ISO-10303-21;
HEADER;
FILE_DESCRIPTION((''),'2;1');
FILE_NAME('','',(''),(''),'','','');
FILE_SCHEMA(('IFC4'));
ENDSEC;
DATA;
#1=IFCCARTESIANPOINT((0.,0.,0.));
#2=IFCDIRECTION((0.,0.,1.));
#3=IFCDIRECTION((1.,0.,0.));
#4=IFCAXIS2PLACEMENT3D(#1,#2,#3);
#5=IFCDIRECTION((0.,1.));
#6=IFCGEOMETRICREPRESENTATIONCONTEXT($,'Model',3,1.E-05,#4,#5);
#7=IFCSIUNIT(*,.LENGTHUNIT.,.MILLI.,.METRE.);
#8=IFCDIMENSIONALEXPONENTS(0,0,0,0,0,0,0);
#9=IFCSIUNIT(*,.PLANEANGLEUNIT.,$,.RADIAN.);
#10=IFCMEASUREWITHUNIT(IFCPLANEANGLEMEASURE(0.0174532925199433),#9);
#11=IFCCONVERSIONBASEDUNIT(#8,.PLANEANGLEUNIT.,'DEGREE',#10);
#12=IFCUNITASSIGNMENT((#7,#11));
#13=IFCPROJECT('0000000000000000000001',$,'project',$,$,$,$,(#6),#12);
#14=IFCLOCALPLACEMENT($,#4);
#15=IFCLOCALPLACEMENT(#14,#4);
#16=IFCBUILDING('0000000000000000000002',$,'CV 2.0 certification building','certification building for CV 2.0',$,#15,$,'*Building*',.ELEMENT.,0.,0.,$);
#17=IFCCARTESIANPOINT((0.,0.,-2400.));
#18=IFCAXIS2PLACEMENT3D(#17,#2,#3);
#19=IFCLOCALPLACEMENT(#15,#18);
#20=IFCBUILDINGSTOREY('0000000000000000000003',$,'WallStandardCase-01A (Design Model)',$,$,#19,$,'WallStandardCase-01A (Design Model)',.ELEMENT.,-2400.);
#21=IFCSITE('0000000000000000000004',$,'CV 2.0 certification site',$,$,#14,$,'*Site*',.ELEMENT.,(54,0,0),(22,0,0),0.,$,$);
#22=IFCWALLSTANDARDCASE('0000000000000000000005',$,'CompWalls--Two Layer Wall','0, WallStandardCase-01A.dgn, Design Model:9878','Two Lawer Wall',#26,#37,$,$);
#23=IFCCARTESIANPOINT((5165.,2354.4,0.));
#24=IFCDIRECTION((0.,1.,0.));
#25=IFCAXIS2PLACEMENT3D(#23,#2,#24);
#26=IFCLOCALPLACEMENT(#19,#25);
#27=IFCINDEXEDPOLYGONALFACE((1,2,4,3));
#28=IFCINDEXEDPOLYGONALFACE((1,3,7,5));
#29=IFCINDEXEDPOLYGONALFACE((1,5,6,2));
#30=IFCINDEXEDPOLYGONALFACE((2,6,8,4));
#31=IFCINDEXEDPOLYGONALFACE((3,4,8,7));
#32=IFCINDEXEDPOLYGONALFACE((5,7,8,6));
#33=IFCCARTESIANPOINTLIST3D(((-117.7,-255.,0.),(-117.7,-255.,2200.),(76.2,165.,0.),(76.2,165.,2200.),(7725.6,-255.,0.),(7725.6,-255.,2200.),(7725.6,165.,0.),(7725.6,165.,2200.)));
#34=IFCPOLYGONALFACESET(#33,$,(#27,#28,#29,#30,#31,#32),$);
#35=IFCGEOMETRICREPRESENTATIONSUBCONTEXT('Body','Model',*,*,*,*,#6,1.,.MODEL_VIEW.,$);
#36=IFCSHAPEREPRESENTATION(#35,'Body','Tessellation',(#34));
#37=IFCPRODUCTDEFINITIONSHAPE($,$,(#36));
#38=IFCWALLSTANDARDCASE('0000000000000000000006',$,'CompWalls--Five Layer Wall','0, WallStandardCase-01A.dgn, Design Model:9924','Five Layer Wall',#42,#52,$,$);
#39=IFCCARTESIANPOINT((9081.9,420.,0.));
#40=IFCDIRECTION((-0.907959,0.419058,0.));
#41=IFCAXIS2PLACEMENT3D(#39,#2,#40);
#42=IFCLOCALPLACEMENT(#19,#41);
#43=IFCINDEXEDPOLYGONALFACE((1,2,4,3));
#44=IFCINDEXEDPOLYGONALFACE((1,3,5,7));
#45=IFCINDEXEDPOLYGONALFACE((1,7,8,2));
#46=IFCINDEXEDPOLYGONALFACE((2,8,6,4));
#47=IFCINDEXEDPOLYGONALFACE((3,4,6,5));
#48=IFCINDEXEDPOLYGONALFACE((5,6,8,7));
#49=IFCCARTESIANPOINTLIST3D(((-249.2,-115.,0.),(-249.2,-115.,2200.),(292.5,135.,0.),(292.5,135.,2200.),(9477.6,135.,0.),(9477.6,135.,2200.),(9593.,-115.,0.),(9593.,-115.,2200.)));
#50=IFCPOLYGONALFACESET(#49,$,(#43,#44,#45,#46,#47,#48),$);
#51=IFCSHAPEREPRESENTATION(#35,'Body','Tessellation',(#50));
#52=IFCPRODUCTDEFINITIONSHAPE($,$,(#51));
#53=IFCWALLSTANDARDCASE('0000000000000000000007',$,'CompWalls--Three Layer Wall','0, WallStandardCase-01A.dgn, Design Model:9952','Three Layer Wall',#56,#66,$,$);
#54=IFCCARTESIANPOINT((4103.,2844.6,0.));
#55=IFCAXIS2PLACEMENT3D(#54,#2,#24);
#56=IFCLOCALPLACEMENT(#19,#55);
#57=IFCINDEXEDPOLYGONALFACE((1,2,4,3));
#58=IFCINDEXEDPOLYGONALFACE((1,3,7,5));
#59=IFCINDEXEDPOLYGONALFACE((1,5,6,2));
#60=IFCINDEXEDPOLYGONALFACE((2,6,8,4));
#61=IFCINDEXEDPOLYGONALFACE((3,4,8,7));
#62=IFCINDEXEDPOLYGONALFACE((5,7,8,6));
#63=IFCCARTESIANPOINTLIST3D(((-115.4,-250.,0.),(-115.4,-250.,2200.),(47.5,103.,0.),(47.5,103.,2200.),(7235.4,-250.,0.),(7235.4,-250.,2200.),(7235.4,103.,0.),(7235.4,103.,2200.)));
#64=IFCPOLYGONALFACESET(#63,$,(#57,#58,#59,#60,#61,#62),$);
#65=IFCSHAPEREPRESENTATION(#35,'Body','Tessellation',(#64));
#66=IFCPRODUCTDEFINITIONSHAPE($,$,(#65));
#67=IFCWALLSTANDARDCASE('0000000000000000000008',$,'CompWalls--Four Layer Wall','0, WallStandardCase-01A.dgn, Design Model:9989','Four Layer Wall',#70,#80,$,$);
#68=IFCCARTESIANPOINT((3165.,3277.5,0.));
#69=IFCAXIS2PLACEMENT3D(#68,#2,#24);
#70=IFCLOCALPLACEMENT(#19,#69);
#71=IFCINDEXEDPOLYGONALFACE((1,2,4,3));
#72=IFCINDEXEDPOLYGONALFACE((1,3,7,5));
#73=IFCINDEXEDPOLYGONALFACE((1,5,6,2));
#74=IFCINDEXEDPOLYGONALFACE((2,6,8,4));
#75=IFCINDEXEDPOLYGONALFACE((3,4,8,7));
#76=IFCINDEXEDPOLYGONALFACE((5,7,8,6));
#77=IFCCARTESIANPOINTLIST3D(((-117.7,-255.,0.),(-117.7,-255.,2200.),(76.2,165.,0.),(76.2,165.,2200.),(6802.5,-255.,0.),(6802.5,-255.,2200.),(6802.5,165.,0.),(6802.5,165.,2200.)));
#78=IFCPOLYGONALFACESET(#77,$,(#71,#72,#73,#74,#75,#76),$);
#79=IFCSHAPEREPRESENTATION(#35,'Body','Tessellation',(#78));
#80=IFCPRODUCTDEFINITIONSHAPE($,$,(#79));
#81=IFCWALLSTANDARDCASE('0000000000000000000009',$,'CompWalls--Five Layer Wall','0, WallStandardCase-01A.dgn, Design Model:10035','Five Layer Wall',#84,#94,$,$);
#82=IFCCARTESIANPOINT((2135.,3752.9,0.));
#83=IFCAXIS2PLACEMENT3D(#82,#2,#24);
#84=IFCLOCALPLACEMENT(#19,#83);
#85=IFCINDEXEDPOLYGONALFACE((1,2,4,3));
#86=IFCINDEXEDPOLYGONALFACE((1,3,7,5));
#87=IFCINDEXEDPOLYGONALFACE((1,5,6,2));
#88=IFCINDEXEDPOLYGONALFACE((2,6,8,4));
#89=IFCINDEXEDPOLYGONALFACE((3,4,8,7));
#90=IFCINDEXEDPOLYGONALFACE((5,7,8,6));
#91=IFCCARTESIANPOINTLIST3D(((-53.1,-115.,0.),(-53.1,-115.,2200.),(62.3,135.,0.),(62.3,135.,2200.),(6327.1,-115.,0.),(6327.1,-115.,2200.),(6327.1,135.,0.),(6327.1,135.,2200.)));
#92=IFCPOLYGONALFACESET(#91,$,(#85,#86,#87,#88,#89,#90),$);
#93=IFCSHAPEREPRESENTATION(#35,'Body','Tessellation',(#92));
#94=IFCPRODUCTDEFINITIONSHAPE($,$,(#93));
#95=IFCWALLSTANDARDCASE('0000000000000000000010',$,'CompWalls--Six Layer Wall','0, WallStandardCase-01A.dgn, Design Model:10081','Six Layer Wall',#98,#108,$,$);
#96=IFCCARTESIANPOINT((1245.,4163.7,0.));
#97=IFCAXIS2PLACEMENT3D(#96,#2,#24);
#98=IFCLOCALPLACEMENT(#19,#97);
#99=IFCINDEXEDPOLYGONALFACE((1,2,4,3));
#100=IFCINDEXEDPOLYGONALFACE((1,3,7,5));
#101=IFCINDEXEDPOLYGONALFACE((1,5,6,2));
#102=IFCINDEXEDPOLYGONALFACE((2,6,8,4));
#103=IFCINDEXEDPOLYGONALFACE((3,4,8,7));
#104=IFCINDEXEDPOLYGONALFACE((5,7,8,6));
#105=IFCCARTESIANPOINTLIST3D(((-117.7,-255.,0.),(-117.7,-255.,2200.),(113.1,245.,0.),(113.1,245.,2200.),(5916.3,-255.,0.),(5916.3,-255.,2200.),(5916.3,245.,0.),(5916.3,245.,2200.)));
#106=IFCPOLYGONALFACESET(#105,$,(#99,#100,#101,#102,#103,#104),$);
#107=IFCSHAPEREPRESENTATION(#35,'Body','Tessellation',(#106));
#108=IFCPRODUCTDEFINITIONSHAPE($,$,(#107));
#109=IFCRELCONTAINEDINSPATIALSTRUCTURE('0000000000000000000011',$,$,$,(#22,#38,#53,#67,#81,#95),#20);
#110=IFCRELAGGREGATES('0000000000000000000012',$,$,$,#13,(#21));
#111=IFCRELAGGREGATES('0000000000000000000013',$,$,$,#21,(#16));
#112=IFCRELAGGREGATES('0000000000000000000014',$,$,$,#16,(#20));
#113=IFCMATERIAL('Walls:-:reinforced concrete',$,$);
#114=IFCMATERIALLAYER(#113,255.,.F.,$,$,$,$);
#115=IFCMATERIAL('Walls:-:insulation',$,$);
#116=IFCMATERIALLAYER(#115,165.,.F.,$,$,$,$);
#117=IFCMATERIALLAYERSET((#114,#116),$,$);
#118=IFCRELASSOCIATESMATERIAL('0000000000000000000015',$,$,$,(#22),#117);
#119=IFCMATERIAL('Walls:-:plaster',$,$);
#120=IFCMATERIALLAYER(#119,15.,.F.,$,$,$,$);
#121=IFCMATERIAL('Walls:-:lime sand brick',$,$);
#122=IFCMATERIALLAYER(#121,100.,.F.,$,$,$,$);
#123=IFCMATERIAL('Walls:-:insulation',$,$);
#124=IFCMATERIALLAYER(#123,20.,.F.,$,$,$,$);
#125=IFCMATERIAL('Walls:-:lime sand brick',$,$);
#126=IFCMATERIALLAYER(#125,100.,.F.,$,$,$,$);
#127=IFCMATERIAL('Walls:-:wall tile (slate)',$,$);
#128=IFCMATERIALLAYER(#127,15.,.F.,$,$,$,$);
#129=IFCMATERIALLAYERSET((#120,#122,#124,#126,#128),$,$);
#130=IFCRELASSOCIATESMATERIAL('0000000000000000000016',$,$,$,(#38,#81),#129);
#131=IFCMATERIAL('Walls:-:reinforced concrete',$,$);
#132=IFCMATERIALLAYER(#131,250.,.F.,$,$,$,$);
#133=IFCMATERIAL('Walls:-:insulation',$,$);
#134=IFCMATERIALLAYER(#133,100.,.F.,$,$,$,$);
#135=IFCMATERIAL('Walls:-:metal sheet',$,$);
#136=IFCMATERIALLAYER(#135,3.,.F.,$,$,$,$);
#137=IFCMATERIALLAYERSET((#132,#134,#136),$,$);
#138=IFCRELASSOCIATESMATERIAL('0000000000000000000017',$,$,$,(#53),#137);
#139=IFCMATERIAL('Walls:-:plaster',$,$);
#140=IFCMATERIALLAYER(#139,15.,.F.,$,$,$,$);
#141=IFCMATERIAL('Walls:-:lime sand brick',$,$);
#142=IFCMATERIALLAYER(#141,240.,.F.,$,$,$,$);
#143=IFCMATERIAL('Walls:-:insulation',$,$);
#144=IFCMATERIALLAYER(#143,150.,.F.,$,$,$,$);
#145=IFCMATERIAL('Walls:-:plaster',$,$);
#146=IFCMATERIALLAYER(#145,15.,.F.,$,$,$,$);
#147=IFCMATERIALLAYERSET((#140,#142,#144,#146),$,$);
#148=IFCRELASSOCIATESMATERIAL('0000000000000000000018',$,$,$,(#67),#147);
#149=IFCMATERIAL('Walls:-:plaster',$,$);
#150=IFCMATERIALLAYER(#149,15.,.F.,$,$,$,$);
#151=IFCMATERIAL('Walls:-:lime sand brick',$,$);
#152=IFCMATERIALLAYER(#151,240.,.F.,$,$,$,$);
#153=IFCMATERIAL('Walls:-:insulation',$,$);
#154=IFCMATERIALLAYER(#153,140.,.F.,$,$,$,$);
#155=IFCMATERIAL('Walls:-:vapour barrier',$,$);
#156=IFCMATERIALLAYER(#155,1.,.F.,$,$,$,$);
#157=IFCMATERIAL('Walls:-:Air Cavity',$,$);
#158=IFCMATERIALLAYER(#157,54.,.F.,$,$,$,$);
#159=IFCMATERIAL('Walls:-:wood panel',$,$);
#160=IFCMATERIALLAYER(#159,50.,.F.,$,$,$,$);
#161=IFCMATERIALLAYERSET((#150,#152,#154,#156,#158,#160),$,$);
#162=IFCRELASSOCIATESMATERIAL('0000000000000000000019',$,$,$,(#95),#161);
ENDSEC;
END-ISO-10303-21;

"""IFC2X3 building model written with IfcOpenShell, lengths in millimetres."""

from ifc_helpers import new_model, entity, si_unit, converted_unit, direction, frame, origin_with_axes, place, context, subcontext, project, spatial, polyline, outline, extrude, material, layer, layer_set, layer_usage, element, save


model = new_model("IFC2X3")

# Units and contexts
model_context = context("Model", 3, precision=1e-05, world=origin_with_axes(), true_north=direction((0.0, 1.0)))
body_context = subcontext(model_context, "Body", "Model", "MODEL_VIEW", scale=1.0)
ifc_project = project(units=[si_unit("LENGTHUNIT", "METRE", prefix="MILLI"), converted_unit("PLANEANGLEUNIT", "DEGREE", entity("IfcPlaneAngleMeasure", 0.0174532925199433), si_unit("PLANEANGLEUNIT", "RADIAN"), dimensions=[0, 0, 0, 0, 0, 0, 0])], contexts=[model_context])

# Site, building, storey
site_placement = place(None, origin_with_axes())
site = spatial("IfcSite", under=ifc_project, at=site_placement, Name="CV 2.0 certification site", LongName="*Site*", CompositionType="ELEMENT", RefLatitude=(54, 0, 0), RefLongitude=(22, 0, 0), RefElevation=0.0)
building_placement = place(site_placement, origin_with_axes())
building = spatial("IfcBuilding", under=site, at=building_placement, Name="CV 2.0 certification building", Description="certification building for CV 2.0", LongName="*Building*", CompositionType="ELEMENT", ElevationOfRefHeight=0.0, ElevationOfTerrain=0.0)
storey_placement = place(building_placement, frame((0.0, 0.0, -2400.0), z_axis=(0.0, 0.0, 1.0), x_axis=(1.0, 0.0, 0.0)))
storey = spatial("IfcBuildingStorey", under=building, at=storey_placement, Name="WallStandardCase-01A (Design Model)", LongName="WallStandardCase-01A (Design Model)", CompositionType="ELEMENT", Elevation=-2400.0)

# Walls
ifc_material_1 = material(Name="Walls:-:reinforced concrete")
ifc_layer_1 = layer(ifc_material_1, 255.0, ventilated=False)
ifc_material_2 = material(Name="Walls:-:insulation")
ifc_layer_2 = layer(ifc_material_2, 165.0, ventilated=False)
ifc_layer_set_1 = layer_set([ifc_layer_1, ifc_layer_2])
ifc_layer_usage_1 = layer_usage(ifc_layer_set_1, "AXIS2", "POSITIVE", 0.0)
wall_1_placement = place(storey_placement, frame((5165.0, 2354.4, 0.0), z_axis=(0.0, 0.0, 1.0), x_axis=(0.0, 1.0, 0.0)))
element("IfcWallStandardCase", 1, at=wall_1_placement, inside=storey, material=ifc_layer_usage_1, Name="CompWalls--Two Layer Wall", Description="0, WallStandardCase-01A.dgn, Design Model:9878", ObjectType="Two Lawer Wall", context=body_context, shape_type="SweptSolid", body=[
    extrude(outline(polyline([(7725.6, 165.0), (76.2, 165.0), (-117.7, -255.0), (7725.6, -255.0), (7725.6, 165.0)])), origin_with_axes(), (0.0, 0.0, 1.0), 2200.0),
])
ifc_material_3 = material(Name="Walls:-:plaster")
ifc_layer_3 = layer(ifc_material_3, 15.0, ventilated=False)
ifc_material_4 = material(Name="Walls:-:lime sand brick")
ifc_layer_4 = layer(ifc_material_4, 100.0, ventilated=False)
ifc_material_5 = material(Name="Walls:-:insulation")
ifc_layer_5 = layer(ifc_material_5, 20.0, ventilated=False)
ifc_material_6 = material(Name="Walls:-:lime sand brick")
ifc_layer_6 = layer(ifc_material_6, 100.0, ventilated=False)
ifc_material_7 = material(Name="Walls:-:wall tile (slate)")
ifc_layer_7 = layer(ifc_material_7, 15.0, ventilated=False)
ifc_layer_set_2 = layer_set([ifc_layer_3, ifc_layer_4, ifc_layer_5, ifc_layer_6, ifc_layer_7])
ifc_layer_usage_2 = layer_usage(ifc_layer_set_2, "AXIS2", "POSITIVE", 0.0)
wall_2_placement = place(storey_placement, frame((9081.9, 420.0, 0.0), z_axis=(0.0, 0.0, 1.0), x_axis=(-0.907959, 0.419058, 0.0)))
element("IfcWallStandardCase", 2, at=wall_2_placement, inside=storey, material=ifc_layer_usage_2, Name="CompWalls--Five Layer Wall", Description="0, WallStandardCase-01A.dgn, Design Model:9924", ObjectType="Five Layer Wall", context=body_context, shape_type="SweptSolid", body=[
    extrude(outline(polyline([(9477.6, 135.0), (292.5, 135.0), (-249.2, -115.0), (9593.0, -115.0), (9477.6, 135.0)])), origin_with_axes(), (0.0, 0.0, 1.0), 2200.0),
])
ifc_material_8 = material(Name="Walls:-:reinforced concrete")
ifc_layer_8 = layer(ifc_material_8, 250.0, ventilated=False)
ifc_material_9 = material(Name="Walls:-:insulation")
ifc_layer_9 = layer(ifc_material_9, 100.0, ventilated=False)
ifc_material_10 = material(Name="Walls:-:metal sheet")
ifc_layer_10 = layer(ifc_material_10, 3.0, ventilated=False)
ifc_layer_set_3 = layer_set([ifc_layer_8, ifc_layer_9, ifc_layer_10])
ifc_layer_usage_3 = layer_usage(ifc_layer_set_3, "AXIS2", "POSITIVE", 0.0)
wall_3_placement = place(storey_placement, frame((4103.0, 2844.6, 0.0), z_axis=(0.0, 0.0, 1.0), x_axis=(0.0, 1.0, 0.0)))
element("IfcWallStandardCase", 3, at=wall_3_placement, inside=storey, material=ifc_layer_usage_3, Name="CompWalls--Three Layer Wall", Description="0, WallStandardCase-01A.dgn, Design Model:9952", ObjectType="Three Layer Wall", context=body_context, shape_type="SweptSolid", body=[
    extrude(outline(polyline([(7235.4, 103.0), (47.5, 103.0), (-115.4, -250.0), (7235.4, -250.0), (7235.4, 103.0)])), origin_with_axes(), (0.0, 0.0, 1.0), 2200.0),
])
ifc_material_11 = material(Name="Walls:-:plaster")
ifc_layer_11 = layer(ifc_material_11, 15.0, ventilated=False)
ifc_material_12 = material(Name="Walls:-:lime sand brick")
ifc_layer_12 = layer(ifc_material_12, 240.0, ventilated=False)
ifc_material_13 = material(Name="Walls:-:insulation")
ifc_layer_13 = layer(ifc_material_13, 150.0, ventilated=False)
ifc_material_14 = material(Name="Walls:-:plaster")
ifc_layer_14 = layer(ifc_material_14, 15.0, ventilated=False)
ifc_layer_set_4 = layer_set([ifc_layer_11, ifc_layer_12, ifc_layer_13, ifc_layer_14])
ifc_layer_usage_4 = layer_usage(ifc_layer_set_4, "AXIS2", "POSITIVE", 0.0)
wall_4_placement = place(storey_placement, frame((3165.0, 3277.5, 0.0), z_axis=(0.0, 0.0, 1.0), x_axis=(0.0, 1.0, 0.0)))
element("IfcWallStandardCase", 4, at=wall_4_placement, inside=storey, material=ifc_layer_usage_4, Name="CompWalls--Four Layer Wall", Description="0, WallStandardCase-01A.dgn, Design Model:9989", ObjectType="Four Layer Wall", context=body_context, shape_type="SweptSolid", body=[
    extrude(outline(polyline([(6802.5, 165.0), (76.2, 165.0), (-117.7, -255.0), (6802.5, -255.0), (6802.5, 165.0)])), origin_with_axes(), (0.0, 0.0, 1.0), 2200.0),
])
wall_5_placement = place(storey_placement, frame((2135.0, 3752.9, 0.0), z_axis=(0.0, 0.0, 1.0), x_axis=(0.0, 1.0, 0.0)))
element("IfcWallStandardCase", 5, at=wall_5_placement, inside=storey, material=ifc_layer_usage_2, Name="CompWalls--Five Layer Wall", Description="0, WallStandardCase-01A.dgn, Design Model:10035", ObjectType="Five Layer Wall", context=body_context, shape_type="SweptSolid", body=[
    extrude(outline(polyline([(6327.1, 135.0), (62.3, 135.0), (-53.1, -115.0), (6327.1, -115.0), (6327.1, 135.0)])), origin_with_axes(), (0.0, 0.0, 1.0), 2200.0),
])
ifc_material_15 = material(Name="Walls:-:plaster")
ifc_layer_15 = layer(ifc_material_15, 15.0, ventilated=False)
ifc_material_16 = material(Name="Walls:-:lime sand brick")
ifc_layer_16 = layer(ifc_material_16, 240.0, ventilated=False)
ifc_material_17 = material(Name="Walls:-:insulation")
ifc_layer_17 = layer(ifc_material_17, 140.0, ventilated=False)
ifc_material_18 = material(Name="Walls:-:vapour barrier")
ifc_layer_18 = layer(ifc_material_18, 1.0, ventilated=False)
ifc_material_19 = material(Name="Walls:-:Air Cavity")
ifc_layer_19 = layer(ifc_material_19, 54.0, ventilated=False)
ifc_material_20 = material(Name="Walls:-:wood panel")
ifc_layer_20 = layer(ifc_material_20, 50.0, ventilated=False)
ifc_layer_set_5 = layer_set([ifc_layer_15, ifc_layer_16, ifc_layer_17, ifc_layer_18, ifc_layer_19, ifc_layer_20])
ifc_layer_usage_5 = layer_usage(ifc_layer_set_5, "AXIS2", "POSITIVE", 0.0)
wall_6_placement = place(storey_placement, frame((1245.0, 4163.7, 0.0), z_axis=(0.0, 0.0, 1.0), x_axis=(0.0, 1.0, 0.0)))
element("IfcWallStandardCase", 6, at=wall_6_placement, inside=storey, material=ifc_layer_usage_5, Name="CompWalls--Six Layer Wall", Description="0, WallStandardCase-01A.dgn, Design Model:10081", ObjectType="Six Layer Wall", context=body_context, shape_type="SweptSolid", body=[
    extrude(outline(polyline([(5916.3, 245.0), (113.1, 245.0), (-117.7, -255.0), (5916.3, -255.0), (5916.3, 245.0)])), origin_with_axes(), (0.0, 0.0, 1.0), 2200.0),
])

save(model, "model.ifc")
